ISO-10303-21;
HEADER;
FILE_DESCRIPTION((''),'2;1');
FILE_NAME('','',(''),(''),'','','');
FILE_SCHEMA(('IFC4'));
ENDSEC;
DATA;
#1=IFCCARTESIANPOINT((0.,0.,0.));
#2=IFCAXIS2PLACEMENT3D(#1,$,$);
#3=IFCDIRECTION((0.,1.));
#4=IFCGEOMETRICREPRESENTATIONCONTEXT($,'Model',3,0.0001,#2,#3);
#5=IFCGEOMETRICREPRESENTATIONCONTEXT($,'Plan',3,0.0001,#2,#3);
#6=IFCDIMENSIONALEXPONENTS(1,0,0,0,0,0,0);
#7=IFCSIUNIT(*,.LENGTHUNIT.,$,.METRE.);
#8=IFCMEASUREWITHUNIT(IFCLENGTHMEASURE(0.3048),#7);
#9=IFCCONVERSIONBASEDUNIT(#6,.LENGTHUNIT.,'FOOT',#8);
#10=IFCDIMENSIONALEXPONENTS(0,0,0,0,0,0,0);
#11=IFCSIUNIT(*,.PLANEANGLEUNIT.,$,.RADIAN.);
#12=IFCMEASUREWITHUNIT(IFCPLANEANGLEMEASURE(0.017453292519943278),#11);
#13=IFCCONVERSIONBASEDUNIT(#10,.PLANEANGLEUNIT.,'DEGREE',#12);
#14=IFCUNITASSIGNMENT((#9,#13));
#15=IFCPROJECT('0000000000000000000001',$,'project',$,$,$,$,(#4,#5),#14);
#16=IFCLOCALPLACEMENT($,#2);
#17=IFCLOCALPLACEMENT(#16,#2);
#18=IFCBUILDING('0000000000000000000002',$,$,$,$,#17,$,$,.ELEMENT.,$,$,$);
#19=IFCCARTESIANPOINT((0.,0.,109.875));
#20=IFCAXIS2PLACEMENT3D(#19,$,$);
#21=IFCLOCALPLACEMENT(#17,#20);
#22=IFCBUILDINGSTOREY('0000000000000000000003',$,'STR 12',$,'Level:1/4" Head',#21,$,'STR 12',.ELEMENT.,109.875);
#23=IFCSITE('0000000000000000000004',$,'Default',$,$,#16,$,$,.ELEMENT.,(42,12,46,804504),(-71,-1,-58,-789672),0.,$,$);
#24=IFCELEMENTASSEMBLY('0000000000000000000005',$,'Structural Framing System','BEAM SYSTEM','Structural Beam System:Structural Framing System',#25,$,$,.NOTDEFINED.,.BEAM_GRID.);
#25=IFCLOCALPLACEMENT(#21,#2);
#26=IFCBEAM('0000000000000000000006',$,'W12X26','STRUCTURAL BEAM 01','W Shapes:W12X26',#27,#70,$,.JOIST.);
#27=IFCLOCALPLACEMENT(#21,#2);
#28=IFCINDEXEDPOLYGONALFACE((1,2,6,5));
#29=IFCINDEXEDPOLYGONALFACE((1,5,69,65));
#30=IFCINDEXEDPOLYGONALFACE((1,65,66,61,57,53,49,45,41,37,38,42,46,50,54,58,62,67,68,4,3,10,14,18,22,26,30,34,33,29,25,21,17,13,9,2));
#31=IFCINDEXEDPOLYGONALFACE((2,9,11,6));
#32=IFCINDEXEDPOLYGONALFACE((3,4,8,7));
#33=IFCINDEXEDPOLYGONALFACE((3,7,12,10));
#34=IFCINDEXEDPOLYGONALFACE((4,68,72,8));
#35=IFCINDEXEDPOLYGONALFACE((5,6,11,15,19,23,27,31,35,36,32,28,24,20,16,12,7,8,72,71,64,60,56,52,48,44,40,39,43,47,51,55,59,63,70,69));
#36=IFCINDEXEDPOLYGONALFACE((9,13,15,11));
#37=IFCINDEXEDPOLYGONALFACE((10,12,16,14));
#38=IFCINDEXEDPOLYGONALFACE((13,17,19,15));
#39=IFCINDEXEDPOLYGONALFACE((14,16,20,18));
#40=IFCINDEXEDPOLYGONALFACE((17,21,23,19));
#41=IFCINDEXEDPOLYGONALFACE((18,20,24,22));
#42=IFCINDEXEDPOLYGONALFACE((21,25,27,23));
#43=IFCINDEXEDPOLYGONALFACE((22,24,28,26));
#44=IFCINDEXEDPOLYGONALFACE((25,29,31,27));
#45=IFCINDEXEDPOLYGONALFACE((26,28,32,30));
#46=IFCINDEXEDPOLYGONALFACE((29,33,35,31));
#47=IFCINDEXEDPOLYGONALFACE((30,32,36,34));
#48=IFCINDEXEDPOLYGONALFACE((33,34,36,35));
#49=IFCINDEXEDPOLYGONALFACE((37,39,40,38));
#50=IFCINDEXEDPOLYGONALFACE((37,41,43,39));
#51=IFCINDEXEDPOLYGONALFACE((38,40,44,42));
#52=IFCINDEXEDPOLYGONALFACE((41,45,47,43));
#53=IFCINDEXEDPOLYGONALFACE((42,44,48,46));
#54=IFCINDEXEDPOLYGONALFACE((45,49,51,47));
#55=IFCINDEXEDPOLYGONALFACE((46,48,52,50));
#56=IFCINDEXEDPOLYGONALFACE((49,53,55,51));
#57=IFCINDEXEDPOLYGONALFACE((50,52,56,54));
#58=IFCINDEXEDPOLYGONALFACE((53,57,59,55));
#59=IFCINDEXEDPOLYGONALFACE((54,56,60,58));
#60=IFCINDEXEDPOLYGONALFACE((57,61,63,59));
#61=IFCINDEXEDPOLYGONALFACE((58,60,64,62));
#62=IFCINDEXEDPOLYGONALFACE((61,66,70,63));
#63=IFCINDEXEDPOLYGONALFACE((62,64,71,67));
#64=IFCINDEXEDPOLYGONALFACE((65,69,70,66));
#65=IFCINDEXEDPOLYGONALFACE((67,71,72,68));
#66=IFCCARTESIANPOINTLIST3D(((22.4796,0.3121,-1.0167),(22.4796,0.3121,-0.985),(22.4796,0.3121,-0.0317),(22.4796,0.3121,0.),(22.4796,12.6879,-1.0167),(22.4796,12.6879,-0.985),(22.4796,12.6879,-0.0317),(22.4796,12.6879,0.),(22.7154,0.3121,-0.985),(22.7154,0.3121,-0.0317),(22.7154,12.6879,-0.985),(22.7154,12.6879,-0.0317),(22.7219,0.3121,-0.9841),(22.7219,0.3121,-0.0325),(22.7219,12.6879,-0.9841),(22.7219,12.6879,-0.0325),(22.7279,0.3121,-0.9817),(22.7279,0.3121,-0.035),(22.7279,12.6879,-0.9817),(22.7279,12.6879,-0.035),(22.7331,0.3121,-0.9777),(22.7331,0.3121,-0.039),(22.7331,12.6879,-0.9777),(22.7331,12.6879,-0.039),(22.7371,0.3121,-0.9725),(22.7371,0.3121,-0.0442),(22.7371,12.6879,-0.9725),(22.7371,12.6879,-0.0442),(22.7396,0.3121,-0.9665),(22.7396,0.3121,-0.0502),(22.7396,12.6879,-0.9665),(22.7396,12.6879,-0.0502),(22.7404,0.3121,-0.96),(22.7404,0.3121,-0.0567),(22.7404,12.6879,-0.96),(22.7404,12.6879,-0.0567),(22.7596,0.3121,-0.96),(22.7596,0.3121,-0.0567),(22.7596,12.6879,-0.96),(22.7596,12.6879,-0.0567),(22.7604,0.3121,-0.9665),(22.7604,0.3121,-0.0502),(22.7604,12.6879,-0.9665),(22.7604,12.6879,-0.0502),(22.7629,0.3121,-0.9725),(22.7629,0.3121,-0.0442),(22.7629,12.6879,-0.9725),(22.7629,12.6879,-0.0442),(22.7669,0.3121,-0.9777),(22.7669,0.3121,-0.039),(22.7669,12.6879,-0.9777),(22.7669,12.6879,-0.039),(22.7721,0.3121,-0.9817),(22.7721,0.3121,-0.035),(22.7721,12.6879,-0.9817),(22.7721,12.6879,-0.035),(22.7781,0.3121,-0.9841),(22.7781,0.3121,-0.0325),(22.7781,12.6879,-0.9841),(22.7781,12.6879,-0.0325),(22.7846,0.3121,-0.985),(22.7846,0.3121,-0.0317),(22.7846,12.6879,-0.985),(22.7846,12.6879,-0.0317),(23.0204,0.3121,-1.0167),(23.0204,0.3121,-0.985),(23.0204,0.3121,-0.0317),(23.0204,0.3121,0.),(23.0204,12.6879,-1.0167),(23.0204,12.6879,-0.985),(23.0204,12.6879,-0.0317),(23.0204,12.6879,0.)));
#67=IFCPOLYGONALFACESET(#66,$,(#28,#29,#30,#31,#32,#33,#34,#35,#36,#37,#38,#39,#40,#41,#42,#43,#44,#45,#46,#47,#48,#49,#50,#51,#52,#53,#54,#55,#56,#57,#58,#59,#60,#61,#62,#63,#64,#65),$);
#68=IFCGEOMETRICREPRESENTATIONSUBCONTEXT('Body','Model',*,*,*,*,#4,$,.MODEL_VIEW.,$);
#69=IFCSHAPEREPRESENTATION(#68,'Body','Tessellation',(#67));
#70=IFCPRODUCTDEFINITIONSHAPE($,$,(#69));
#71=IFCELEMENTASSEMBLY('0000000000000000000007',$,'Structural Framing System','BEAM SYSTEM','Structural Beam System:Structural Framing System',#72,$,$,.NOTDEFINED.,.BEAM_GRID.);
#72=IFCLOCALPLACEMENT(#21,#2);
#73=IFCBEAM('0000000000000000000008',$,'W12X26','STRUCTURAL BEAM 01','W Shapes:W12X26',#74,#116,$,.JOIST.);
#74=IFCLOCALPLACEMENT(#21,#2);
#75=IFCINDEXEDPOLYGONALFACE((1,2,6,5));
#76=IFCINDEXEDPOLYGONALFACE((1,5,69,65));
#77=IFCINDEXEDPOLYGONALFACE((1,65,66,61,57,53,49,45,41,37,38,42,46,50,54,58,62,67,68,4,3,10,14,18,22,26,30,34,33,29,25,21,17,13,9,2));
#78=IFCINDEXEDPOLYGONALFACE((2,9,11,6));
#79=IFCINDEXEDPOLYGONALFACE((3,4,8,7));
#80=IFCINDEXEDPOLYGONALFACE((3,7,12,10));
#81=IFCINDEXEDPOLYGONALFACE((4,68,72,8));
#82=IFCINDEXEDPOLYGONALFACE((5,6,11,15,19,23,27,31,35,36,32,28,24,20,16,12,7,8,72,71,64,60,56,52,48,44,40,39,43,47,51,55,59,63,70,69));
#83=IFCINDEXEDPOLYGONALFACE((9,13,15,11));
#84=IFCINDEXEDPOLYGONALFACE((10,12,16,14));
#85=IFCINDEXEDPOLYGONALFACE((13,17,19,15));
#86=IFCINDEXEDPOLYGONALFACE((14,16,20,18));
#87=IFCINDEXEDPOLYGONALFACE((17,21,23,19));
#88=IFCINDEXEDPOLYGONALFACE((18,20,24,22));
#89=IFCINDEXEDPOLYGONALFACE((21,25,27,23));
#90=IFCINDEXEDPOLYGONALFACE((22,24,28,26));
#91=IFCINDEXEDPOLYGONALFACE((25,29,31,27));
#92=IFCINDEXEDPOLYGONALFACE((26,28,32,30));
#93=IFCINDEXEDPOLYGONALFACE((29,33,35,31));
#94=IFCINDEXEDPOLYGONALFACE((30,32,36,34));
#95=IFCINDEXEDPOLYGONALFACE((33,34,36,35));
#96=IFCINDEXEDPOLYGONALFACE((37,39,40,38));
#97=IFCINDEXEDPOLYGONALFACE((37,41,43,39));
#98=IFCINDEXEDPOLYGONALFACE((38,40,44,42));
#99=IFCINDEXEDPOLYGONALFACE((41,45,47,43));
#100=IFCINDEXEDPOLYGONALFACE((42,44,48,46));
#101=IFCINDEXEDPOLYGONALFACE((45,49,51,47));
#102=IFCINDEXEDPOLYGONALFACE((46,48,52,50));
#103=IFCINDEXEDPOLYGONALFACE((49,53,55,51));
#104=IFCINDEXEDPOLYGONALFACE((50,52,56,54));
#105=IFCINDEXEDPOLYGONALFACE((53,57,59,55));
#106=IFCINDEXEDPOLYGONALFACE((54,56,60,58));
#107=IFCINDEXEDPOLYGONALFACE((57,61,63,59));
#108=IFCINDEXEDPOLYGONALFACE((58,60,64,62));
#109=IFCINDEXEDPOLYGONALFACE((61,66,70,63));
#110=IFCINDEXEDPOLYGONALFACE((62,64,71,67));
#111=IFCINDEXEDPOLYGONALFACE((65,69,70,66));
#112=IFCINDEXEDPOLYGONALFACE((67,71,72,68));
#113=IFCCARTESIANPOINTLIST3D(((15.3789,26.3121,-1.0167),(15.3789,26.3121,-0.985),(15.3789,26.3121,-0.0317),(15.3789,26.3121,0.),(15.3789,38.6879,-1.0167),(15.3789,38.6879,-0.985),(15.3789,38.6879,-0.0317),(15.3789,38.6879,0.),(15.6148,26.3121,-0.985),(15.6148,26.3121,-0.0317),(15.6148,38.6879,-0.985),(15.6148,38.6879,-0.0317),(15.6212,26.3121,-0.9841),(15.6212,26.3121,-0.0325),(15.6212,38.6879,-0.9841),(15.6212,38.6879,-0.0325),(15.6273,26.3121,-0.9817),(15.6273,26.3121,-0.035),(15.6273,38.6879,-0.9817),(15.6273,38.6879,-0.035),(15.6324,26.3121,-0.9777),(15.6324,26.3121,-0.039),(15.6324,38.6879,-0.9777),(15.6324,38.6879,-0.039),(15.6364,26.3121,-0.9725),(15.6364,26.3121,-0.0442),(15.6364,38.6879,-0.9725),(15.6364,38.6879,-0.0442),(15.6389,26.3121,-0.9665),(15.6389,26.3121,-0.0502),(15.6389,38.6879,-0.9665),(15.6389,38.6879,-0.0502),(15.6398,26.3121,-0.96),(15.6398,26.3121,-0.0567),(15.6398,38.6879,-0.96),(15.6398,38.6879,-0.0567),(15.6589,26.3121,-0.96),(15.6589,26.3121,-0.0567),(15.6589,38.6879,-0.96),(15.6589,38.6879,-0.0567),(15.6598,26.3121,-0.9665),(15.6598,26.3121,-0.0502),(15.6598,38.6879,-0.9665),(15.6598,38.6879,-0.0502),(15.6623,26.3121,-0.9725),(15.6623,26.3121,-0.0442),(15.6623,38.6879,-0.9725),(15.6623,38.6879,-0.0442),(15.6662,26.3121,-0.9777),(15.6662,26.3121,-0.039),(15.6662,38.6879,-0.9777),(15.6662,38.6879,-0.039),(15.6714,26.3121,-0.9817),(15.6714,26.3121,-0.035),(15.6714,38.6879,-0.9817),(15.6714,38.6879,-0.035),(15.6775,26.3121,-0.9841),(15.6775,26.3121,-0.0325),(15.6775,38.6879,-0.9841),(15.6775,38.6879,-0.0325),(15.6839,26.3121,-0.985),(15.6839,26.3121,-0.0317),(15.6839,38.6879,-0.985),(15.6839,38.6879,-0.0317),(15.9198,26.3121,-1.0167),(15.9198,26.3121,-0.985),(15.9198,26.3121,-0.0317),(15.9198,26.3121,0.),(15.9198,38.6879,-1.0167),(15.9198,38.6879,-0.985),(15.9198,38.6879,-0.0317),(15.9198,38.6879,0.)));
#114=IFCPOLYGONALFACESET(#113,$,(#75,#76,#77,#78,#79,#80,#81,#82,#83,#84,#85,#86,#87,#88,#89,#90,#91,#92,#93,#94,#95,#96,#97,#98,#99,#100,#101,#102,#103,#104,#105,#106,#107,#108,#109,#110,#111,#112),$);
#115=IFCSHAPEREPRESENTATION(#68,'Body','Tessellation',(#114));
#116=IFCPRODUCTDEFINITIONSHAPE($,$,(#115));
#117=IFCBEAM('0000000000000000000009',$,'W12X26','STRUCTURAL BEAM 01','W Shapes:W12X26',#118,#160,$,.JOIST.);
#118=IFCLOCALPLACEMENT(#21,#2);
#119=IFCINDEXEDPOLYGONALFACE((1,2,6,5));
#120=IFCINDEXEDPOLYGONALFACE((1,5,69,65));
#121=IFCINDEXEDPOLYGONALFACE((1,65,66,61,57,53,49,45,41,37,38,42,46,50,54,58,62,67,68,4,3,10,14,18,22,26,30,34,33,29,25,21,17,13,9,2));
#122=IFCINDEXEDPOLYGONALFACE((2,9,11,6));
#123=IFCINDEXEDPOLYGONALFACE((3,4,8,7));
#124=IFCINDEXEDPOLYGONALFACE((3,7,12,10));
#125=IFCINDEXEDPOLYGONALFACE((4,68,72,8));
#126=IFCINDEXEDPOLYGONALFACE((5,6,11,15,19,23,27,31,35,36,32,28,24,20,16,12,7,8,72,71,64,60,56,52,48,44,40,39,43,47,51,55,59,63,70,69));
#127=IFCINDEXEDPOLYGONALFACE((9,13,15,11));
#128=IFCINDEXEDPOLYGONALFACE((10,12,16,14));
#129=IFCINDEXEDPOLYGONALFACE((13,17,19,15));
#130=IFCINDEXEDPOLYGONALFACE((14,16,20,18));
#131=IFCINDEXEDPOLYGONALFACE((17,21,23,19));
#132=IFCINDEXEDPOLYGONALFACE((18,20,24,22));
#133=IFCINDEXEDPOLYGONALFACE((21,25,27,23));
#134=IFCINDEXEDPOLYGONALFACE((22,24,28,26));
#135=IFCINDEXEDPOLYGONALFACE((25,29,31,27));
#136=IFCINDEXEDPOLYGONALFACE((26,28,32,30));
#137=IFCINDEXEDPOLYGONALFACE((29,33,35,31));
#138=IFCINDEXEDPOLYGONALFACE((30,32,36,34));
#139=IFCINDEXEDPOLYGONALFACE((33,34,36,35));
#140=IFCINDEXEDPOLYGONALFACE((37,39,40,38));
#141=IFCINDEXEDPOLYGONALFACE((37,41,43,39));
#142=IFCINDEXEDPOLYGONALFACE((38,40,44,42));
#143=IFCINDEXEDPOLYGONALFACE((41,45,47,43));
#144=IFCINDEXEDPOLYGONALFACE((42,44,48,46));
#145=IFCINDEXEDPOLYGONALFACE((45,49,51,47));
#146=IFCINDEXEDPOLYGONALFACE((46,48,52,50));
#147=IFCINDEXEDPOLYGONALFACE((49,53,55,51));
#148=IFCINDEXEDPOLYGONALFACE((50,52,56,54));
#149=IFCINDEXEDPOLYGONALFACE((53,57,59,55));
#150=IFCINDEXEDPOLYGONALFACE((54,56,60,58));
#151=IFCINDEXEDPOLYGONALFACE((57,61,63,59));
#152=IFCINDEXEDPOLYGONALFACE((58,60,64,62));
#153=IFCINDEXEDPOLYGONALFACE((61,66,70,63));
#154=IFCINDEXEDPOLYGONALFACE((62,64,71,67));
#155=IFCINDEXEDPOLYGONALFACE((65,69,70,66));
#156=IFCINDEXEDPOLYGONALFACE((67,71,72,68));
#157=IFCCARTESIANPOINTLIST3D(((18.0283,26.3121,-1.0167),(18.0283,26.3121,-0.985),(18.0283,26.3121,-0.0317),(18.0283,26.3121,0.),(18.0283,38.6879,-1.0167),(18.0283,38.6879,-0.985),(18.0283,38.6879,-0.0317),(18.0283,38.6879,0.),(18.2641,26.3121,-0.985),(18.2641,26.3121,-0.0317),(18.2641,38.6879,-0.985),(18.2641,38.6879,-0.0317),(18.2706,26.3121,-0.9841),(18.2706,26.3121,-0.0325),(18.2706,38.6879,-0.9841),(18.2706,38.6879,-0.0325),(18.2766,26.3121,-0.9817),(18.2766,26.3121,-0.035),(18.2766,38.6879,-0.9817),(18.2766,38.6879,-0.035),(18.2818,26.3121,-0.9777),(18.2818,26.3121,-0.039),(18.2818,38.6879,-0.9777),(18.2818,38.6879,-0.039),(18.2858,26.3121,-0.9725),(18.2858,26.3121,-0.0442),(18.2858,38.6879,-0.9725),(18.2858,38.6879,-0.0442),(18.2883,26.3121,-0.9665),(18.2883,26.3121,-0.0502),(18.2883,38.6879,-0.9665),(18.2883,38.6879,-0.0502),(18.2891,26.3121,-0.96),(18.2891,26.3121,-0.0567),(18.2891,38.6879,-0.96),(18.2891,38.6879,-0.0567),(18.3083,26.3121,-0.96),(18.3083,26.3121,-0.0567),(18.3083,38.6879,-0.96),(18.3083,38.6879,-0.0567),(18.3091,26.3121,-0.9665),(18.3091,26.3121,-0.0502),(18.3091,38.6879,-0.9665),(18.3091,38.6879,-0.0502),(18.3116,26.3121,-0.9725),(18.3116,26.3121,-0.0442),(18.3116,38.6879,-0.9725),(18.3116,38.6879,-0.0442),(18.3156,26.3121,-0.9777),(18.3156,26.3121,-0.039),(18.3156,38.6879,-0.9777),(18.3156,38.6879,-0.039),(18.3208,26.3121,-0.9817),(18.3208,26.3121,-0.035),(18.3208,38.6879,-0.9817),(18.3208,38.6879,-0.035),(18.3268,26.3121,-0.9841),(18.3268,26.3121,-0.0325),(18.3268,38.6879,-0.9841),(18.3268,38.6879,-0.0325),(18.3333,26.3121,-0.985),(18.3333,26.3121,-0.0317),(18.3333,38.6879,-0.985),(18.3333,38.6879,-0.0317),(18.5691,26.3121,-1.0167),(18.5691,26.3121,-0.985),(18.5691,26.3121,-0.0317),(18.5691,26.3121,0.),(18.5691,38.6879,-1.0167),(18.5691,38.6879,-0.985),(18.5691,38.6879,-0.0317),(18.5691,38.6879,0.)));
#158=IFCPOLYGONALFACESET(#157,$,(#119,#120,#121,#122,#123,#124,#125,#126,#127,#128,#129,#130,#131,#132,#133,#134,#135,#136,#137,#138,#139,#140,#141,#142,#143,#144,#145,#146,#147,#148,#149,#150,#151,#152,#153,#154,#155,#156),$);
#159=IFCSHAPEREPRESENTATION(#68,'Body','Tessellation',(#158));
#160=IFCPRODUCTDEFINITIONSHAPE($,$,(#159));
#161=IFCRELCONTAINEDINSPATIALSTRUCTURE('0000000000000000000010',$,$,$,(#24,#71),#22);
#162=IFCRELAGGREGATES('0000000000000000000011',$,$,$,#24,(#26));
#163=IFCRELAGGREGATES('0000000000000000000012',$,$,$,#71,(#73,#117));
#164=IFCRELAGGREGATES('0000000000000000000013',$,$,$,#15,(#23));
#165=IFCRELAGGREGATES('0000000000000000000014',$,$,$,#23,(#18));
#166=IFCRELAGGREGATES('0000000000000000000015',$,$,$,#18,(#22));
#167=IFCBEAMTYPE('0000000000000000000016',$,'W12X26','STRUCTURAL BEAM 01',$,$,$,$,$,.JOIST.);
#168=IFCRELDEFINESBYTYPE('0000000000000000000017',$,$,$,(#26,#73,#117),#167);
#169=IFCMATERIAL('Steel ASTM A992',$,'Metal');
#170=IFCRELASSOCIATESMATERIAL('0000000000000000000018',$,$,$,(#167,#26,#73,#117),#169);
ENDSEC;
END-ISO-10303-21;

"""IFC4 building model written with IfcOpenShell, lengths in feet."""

from ifc_helpers import new_model, entity, si_unit, converted_unit, direction, frame, origin, place, context, subcontext, project, spatial, line, arc, indexed_curve, outline, extrude, source, transform, mapped, material, type_object, type_shapes, element, aggregate, save


model = new_model("IFC4")

# Units and contexts
model_context = context("Model", 3, precision=0.0001, world=origin(), true_north=direction((0.0, 1.0)))
plan_context = context("Plan", 3, precision=0.0001, world=origin(), true_north=direction((0.0, 1.0)))
body_context = subcontext(model_context, "Body", "Model", "MODEL_VIEW")
ifc_project = project(units=[converted_unit("LENGTHUNIT", "FOOT", entity("IfcLengthMeasure", 0.3048), si_unit("LENGTHUNIT", "METRE"), dimensions=[1, 0, 0, 0, 0, 0, 0]), converted_unit("PLANEANGLEUNIT", "DEGREE", entity("IfcPlaneAngleMeasure", 0.017453292519943278), si_unit("PLANEANGLEUNIT", "RADIAN"), dimensions=[0, 0, 0, 0, 0, 0, 0])], contexts=[model_context, plan_context])

# Site, building, storey
site_placement = place(None, origin())
site = spatial("IfcSite", under=ifc_project, at=site_placement, Name="Default", CompositionType="ELEMENT", RefLatitude=(42, 12, 46, 804504), RefLongitude=(-71, -1, -58, -789672), RefElevation=0.0)
building_placement = place(site_placement, origin())
building = spatial("IfcBuilding", under=site, at=building_placement, CompositionType="ELEMENT")
storey_placement = place(building_placement, frame((0.0, 0.0, 109.875)))
storey = spatial("IfcBuildingStorey", under=building, at=storey_placement, Name="STR 12", ObjectType="Level:1/4\" Head", LongName="STR 12", CompositionType="ELEMENT", Elevation=109.875)

# Element assemblies, beams
ifc_material = material(Name="Steel ASTM A992", Category="Metal")
beam_type = type_object("IfcBeamType", Name="W12X26", Description="STRUCTURAL BEAM 01", PredefinedType="JOIST", material=ifc_material)
shared_shape = source(origin(), body_context, "Body", "SweptSolid", [
    extrude(outline(indexed_curve([(-0.2704, -0.4767), (-0.2704, -0.5083), (0.2704, -0.5083), (0.2704, -0.4767), (0.0346, -0.4767), (0.0169, -0.4693), (0.0096, -0.4517), (0.0096, 0.4517), (0.0169, 0.4693), (0.0346, 0.4767), (0.2704, 0.4767), (0.2704, 0.5083), (-0.2704, 0.5083), (-0.2704, 0.4767), (-0.0346, 0.4767), (-0.0169, 0.4693), (-0.0096, 0.4517), (-0.0096, -0.4517), (-0.0169, -0.4693), (-0.0346, -0.4767)], segments=[line(1, 2, 3, 4, 5), arc(5, 6, 7), line(7, 8), arc(8, 9, 10), line(10, 11, 12, 13, 14, 15), arc(15, 16, 17), line(17, 18), arc(18, 19, 20), line(20, 1)], self_intersect=False)), frame((-6.1879, 0.0, 0.0), z_axis=(-1.0, 0.0, 0.0), x_axis=(0.0, -1.0, 0.0)), (0.0, 0.0, -1.0), 12.3758),
])
type_shapes(beam_type, [shared_shape])
assembly_1_placement = place(storey_placement, origin())
assembly_1 = element("IfcElementAssembly", 1, at=assembly_1_placement, inside=storey, Name="Structural Framing System", Description="BEAM SYSTEM", ObjectType="Structural Beam System:Structural Framing System", AssemblyPlace="NOTDEFINED", PredefinedType="BEAM_GRID")
beam_1_placement = place(assembly_1_placement, frame((22.75, 6.5, -0.5083), z_axis=(0.0, 0.0, 1.0), x_axis=(0.0, 1.0, 0.0)))
beam_1 = element("IfcBeam", 2, at=beam_1_placement, type_object=beam_type, material=ifc_material, Name="W12X26", Description="STRUCTURAL BEAM 01", ObjectType="W Shapes:W12X26", PredefinedType="JOIST", context=body_context, shape_type="MappedRepresentation", body=[
    mapped(shared_shape, transform((0.0, 0.0, 0.0), scale=1.0)),
])
aggregate(assembly_1, [beam_1])
assembly_2_placement = place(storey_placement, origin())
assembly_2 = element("IfcElementAssembly", 3, at=assembly_2_placement, inside=storey, Name="Structural Framing System", Description="BEAM SYSTEM", ObjectType="Structural Beam System:Structural Framing System", AssemblyPlace="NOTDEFINED", PredefinedType="BEAM_GRID")
beam_2_placement = place(assembly_2_placement, frame((15.6493, 32.5, -0.5083), z_axis=(0.0, 0.0, 1.0), x_axis=(0.0, 1.0, 0.0)))
beam_2 = element("IfcBeam", 4, at=beam_2_placement, type_object=beam_type, material=ifc_material, Name="W12X26", Description="STRUCTURAL BEAM 01", ObjectType="W Shapes:W12X26", PredefinedType="JOIST", context=body_context, shape_type="MappedRepresentation", body=[
    mapped(shared_shape, transform((0.0, 0.0, 0.0), scale=1.0)),
])
beam_3_placement = place(assembly_2_placement, frame((18.2987, 32.5, -0.5083), z_axis=(0.0, 0.0, 1.0), x_axis=(0.0, 1.0, 0.0)))
beam_3 = element("IfcBeam", 5, at=beam_3_placement, type_object=beam_type, material=ifc_material, Name="W12X26", Description="STRUCTURAL BEAM 01", ObjectType="W Shapes:W12X26", PredefinedType="JOIST", context=body_context, shape_type="MappedRepresentation", body=[
    mapped(shared_shape, transform((0.0, 0.0, 0.0), scale=1.0)),
])
aggregate(assembly_2, [beam_2, beam_3])

save(model, "model.ifc")
